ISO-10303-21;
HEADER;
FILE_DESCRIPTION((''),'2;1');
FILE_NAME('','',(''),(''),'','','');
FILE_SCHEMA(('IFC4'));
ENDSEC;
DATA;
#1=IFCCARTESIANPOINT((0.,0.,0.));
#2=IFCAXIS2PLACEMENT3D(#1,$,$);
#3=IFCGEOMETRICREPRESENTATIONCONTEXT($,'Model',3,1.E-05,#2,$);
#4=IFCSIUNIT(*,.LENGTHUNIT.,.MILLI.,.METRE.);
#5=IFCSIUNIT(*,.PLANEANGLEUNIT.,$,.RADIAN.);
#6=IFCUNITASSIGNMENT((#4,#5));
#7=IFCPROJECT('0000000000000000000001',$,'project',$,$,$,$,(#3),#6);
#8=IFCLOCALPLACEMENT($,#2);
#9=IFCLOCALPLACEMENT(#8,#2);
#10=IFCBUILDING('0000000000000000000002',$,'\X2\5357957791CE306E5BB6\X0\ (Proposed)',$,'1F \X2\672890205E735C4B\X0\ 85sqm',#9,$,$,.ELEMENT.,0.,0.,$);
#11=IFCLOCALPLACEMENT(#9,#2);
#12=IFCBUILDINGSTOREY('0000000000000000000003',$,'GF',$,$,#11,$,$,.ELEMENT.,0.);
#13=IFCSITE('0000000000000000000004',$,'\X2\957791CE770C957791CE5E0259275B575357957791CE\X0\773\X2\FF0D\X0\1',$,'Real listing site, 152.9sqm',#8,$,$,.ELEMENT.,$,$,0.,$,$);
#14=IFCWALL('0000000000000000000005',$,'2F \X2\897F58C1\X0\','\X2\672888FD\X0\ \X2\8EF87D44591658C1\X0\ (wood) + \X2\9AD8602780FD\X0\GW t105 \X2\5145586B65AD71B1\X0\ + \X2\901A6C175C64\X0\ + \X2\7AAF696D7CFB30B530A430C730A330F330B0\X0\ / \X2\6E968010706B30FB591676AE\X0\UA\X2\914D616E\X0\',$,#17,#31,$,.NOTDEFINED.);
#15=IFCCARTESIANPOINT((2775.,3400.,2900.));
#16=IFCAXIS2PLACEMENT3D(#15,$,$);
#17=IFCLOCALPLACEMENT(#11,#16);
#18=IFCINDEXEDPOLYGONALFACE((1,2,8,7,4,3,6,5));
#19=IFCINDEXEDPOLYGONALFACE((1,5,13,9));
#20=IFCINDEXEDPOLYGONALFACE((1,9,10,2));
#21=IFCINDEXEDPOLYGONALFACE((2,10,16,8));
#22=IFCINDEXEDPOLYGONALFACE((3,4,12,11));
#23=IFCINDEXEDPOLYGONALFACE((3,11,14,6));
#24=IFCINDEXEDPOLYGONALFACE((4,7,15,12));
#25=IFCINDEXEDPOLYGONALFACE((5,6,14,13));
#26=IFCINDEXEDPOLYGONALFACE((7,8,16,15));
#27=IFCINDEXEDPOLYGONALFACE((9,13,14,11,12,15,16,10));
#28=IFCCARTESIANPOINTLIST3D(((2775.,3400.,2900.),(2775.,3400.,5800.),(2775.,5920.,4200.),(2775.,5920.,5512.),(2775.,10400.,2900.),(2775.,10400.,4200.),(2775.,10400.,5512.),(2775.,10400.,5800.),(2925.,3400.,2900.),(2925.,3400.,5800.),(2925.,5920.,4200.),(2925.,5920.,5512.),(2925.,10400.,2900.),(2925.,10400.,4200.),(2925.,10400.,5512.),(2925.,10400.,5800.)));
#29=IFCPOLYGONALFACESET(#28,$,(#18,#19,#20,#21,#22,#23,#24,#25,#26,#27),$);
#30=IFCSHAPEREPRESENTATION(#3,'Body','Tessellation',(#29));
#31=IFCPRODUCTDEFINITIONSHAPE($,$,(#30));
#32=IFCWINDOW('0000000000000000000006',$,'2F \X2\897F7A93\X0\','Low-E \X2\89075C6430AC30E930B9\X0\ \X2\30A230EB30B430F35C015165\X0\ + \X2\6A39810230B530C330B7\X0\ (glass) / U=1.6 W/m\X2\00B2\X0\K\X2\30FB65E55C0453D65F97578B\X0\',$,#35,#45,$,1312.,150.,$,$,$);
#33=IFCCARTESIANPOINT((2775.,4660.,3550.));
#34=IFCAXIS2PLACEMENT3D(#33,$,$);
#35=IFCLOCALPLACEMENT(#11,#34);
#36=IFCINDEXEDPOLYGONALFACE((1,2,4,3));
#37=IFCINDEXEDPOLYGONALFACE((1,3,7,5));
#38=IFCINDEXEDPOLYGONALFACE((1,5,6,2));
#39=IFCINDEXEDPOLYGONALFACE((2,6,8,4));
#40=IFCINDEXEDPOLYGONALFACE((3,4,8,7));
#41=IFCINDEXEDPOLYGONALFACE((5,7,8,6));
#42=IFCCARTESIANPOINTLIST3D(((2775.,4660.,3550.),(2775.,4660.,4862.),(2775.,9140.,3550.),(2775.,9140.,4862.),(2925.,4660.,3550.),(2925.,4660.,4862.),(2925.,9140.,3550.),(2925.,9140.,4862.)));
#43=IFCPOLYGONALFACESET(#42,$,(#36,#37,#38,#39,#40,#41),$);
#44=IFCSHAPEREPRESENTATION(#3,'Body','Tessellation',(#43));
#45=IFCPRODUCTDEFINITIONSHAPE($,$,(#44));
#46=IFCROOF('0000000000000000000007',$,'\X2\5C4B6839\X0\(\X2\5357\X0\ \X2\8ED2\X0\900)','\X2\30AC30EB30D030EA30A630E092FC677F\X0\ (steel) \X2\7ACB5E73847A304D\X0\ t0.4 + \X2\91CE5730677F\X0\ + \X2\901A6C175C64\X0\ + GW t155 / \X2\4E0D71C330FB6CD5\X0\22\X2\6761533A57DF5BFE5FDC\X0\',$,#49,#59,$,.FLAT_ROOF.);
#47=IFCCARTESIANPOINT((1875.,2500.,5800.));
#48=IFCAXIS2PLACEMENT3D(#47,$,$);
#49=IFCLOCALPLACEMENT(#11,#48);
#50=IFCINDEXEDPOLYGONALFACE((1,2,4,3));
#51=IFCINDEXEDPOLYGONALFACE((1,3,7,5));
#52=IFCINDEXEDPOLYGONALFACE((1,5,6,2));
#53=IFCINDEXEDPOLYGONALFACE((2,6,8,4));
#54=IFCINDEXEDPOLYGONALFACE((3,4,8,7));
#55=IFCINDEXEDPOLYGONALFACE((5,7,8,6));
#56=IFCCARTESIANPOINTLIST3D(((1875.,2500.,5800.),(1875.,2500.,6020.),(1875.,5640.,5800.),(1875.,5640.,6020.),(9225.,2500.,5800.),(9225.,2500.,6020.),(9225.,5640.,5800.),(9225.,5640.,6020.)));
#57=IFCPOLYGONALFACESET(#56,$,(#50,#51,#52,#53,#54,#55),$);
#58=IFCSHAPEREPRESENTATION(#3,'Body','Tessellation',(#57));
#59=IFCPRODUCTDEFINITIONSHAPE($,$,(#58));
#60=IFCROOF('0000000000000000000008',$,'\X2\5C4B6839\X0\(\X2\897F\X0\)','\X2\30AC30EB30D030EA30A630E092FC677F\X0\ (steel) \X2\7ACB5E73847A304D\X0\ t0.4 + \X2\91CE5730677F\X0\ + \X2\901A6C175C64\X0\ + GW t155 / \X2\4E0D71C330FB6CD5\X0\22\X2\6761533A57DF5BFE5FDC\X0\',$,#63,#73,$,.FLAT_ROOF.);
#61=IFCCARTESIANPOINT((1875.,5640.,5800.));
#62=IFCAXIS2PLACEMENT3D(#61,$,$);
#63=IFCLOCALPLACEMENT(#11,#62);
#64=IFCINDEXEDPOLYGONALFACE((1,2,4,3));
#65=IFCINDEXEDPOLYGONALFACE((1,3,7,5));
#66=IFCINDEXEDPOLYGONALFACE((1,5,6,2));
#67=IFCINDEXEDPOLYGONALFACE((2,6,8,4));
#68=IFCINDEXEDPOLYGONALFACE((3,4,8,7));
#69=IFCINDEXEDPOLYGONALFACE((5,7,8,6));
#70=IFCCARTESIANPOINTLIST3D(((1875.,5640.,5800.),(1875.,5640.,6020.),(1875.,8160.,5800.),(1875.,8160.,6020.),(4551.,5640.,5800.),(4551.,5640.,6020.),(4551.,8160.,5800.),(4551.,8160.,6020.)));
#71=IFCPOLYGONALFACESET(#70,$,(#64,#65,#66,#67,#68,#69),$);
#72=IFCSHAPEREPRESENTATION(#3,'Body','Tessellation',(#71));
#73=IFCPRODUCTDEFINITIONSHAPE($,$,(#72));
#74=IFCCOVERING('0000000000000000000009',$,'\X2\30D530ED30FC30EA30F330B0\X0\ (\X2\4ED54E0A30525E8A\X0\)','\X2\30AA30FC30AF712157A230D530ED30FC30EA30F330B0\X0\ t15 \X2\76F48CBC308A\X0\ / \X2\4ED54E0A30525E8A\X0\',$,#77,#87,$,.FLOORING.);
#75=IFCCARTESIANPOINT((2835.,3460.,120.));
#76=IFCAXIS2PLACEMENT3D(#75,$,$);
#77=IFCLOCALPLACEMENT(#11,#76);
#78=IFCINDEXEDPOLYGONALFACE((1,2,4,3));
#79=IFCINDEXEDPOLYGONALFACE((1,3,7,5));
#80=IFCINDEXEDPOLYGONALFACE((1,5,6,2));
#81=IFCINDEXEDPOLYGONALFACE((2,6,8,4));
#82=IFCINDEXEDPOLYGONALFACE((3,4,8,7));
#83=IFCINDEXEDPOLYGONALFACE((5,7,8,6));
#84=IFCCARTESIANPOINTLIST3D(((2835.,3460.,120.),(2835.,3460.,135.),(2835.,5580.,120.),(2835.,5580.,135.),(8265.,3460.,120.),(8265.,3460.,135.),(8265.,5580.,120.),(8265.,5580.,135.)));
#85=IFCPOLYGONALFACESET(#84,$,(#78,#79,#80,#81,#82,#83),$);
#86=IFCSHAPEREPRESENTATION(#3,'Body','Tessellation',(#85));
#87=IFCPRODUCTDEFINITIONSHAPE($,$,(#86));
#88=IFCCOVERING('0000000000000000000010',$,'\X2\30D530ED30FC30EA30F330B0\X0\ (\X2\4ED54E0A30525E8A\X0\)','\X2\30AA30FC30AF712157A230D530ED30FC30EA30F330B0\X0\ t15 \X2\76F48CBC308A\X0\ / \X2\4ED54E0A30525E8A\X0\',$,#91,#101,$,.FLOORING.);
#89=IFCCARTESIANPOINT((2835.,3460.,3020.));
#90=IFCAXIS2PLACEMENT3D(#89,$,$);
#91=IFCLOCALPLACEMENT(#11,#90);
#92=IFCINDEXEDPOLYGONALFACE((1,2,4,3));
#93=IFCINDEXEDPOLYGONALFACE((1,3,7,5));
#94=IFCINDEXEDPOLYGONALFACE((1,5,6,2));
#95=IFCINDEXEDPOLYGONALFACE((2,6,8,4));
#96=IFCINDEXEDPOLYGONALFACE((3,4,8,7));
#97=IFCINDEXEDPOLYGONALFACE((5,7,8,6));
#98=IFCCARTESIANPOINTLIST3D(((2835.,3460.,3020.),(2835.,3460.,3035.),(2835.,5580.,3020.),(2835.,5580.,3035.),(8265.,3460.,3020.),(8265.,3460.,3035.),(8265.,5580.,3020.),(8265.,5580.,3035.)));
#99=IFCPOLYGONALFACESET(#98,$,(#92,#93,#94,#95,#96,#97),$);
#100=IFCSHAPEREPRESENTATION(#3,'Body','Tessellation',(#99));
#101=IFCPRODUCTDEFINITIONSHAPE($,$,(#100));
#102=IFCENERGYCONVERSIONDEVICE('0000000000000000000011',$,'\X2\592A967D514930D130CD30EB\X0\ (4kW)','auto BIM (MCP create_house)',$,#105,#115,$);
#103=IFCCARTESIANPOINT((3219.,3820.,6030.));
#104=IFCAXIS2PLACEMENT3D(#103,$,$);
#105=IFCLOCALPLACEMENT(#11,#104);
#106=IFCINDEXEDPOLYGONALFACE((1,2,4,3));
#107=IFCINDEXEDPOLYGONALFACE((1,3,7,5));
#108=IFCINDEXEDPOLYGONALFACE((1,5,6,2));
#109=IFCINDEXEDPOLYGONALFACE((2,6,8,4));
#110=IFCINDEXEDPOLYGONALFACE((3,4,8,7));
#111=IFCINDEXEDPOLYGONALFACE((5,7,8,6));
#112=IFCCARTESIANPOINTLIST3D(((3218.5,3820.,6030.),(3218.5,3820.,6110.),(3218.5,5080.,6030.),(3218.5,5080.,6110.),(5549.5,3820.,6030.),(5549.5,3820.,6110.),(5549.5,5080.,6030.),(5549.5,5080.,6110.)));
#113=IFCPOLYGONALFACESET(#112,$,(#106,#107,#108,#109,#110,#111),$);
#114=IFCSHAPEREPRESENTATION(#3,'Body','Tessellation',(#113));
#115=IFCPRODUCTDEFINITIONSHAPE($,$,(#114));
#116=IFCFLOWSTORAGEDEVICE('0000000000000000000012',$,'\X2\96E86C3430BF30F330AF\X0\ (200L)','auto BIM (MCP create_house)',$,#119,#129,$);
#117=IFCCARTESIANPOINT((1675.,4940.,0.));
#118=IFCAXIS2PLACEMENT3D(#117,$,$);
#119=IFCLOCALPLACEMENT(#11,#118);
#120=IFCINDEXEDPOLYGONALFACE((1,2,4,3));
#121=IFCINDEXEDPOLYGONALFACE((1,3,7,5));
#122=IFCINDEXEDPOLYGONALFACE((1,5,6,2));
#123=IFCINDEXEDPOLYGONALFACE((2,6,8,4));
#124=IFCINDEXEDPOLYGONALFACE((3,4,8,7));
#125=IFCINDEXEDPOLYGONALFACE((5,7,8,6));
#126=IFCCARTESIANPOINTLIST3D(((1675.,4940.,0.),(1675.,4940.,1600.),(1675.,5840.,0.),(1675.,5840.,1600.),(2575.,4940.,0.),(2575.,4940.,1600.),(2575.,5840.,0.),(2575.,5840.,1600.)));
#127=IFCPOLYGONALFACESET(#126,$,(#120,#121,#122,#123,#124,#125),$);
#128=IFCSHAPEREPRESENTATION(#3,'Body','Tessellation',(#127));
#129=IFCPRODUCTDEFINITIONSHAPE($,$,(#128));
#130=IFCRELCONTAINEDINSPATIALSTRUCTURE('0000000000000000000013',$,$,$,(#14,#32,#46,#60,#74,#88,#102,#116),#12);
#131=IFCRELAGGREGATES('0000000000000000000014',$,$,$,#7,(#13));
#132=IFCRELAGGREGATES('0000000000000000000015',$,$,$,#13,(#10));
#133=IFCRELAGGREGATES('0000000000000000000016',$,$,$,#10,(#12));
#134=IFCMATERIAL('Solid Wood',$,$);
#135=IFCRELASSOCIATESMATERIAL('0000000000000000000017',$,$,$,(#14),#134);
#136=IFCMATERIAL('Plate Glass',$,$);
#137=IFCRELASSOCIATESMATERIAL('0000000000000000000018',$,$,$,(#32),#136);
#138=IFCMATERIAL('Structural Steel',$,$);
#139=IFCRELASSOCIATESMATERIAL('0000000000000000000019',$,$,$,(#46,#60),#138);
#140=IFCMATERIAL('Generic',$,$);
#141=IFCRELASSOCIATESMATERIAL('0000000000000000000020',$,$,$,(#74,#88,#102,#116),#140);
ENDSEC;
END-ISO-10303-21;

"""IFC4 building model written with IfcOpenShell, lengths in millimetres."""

from ifc_helpers import new_model, si_unit, frame, frame_2d, origin, place, context, project, spatial, rectangle, extrude, material, element, fill, save


model = new_model("IFC4")

# Units and contexts
model_context = context("Model", 3, precision=1e-05, world=origin())
ifc_project = project(units=[si_unit("LENGTHUNIT", "METRE", prefix="MILLI"), si_unit("PLANEANGLEUNIT", "RADIAN")], contexts=[model_context])

# Site, building, storey
site_placement = place(None, origin())
site = spatial("IfcSite", under=ifc_project, at=site_placement, Name="長野県長野市大字南長野773－1", ObjectType="Real listing site, 152.9sqm", CompositionType="ELEMENT", RefElevation=0.0)
building_placement = place(site_placement, origin())
building = spatial("IfcBuilding", under=site, at=building_placement, Name="南長野の家 (Proposed)", ObjectType="1F 木造平屋 85sqm", CompositionType="ELEMENT", ElevationOfRefHeight=0.0, ElevationOfTerrain=0.0)
storey_placement = place(building_placement, origin())
storey = spatial("IfcBuildingStorey", under=building, at=storey_placement, Name="GF", CompositionType="ELEMENT", Elevation=0.0)

# Shared definitions
ifc_material_1 = material(Name="Solid Wood")
ifc_material_2 = material(Name="Generic")

# Shared definitions
ifc_material_3 = material(Name="Plate Glass")

# Wall, opening, window
wall_1_placement = place(storey_placement, frame((2775.0, 3400.0, 2900.0)))
wall_1 = element("IfcWall", 1, at=wall_1_placement, inside=storey, material=ifc_material_1, Name="2F 西壁", Description="木製 軸組外壁 (wood) + 高性能GW t105 充填断熱 + 通気層 + 窯業系サイディング / 準耐火・外皮UA配慮", PredefinedType="NOTDEFINED", context=model_context, shape_type="SweptSolid", body=[
    extrude(rectangle(XDim=150.0, YDim=7000.0, at=frame_2d((75.0, 3500.0))), frame((2775.0, 3400.0, 2900.0)), (0.0, 0.0, 1.0), 2900.0),
])
opening_1_placement = place(storey_placement, frame((2775.0, 4660.0, 3550.0)))
opening_1 = element("IfcOpeningElement", 2, at=opening_1_placement, cuts=wall_1, PredefinedType="NOTDEFINED", context=model_context, shape_type="SweptSolid", body=[
    extrude(rectangle(XDim=150.0, YDim=4480.0, at=frame_2d((75.0, 2240.0))), frame((2775.0, 4660.0, 3550.0)), (0.0, 0.0, 1.0), 1312.0),
])
window_1_placement = place(storey_placement, frame((2775.0, 4660.0, 3550.0)))
window_1 = element("IfcWindow", 3, at=window_1_placement, inside=storey, material=ifc_material_3, Name="2F 西窓", Description="Low-E 複層ガラス アルゴン封入 + 樹脂サッシ (glass) / U=1.6 W/m²K・日射取得型", OverallHeight=1312.0, OverallWidth=150.0, context=model_context, shape_type="SweptSolid", body=[
    extrude(rectangle(XDim=150.0, YDim=4480.0, at=frame_2d((75.0, 2240.0))), frame((2775.0, 4660.0, 3550.0)), (0.0, 0.0, 1.0), 1312.0),
])
fill(opening_1, window_1)

# Roofs
ifc_material_4 = material(Name="Structural Steel")
roof_1_placement = place(storey_placement, frame((1875.0, 2500.0, 5800.0)))
element("IfcRoof", 4, at=roof_1_placement, inside=storey, material=ifc_material_4, Name="屋根(南 軒900)", Description="ガルバリウム鋼板 (steel) 立平葺き t0.4 + 野地板 + 通気層 + GW t155 / 不燃・法22条区域対応", PredefinedType="FLAT_ROOF", context=model_context, shape_type="SweptSolid", body=[
    extrude(rectangle(XDim=7350.0, YDim=3140.0, at=frame_2d((3675.0, 1570.0))), frame((1875.0, 2500.0, 5800.0)), (0.0, 0.0, 1.0), 220.0),
])
roof_2_placement = place(storey_placement, frame((1875.0, 5640.0, 5800.0)))
element("IfcRoof", 5, at=roof_2_placement, inside=storey, material=ifc_material_4, Name="屋根(西)", Description="ガルバリウム鋼板 (steel) 立平葺き t0.4 + 野地板 + 通気層 + GW t155 / 不燃・法22条区域対応", PredefinedType="FLAT_ROOF", context=model_context, shape_type="SweptSolid", body=[
    extrude(rectangle(XDim=2676.0, YDim=2520.0, at=frame_2d((1338.0, 1260.0))), frame((1875.0, 5640.0, 5800.0)), (0.0, 0.0, 1.0), 220.0),
])

# Coverings
covering_1_placement = place(storey_placement, frame((2835.0, 3460.0, 120.0)))
element("IfcCovering", 6, at=covering_1_placement, inside=storey, material=ifc_material_2, Name="フローリング (仕上げ床)", Description="オーク無垢フローリング t15 直貼り / 仕上げ床", PredefinedType="FLOORING", context=model_context, shape_type="SweptSolid", body=[
    extrude(rectangle(XDim=5430.0, YDim=2120.0, at=frame_2d((2715.0, 1060.0))), frame((2835.0, 3460.0, 120.0)), (0.0, 0.0, 1.0), 15.0),
])
covering_2_placement = place(storey_placement, frame((2835.0, 3460.0, 3020.0)))
element("IfcCovering", 7, at=covering_2_placement, inside=storey, material=ifc_material_2, Name="フローリング (仕上げ床)", Description="オーク無垢フローリング t15 直貼り / 仕上げ床", PredefinedType="FLOORING", context=model_context, shape_type="SweptSolid", body=[
    extrude(rectangle(XDim=5430.0, YDim=2120.0, at=frame_2d((2715.0, 1060.0))), frame((2835.0, 3460.0, 3020.0)), (0.0, 0.0, 1.0), 15.0),
])

# Energy conversion device
energy_conversion_device_placement = place(storey_placement, frame((3219.0, 3820.0, 6030.0)))
element("IfcEnergyConversionDevice", 8, at=energy_conversion_device_placement, inside=storey, material=ifc_material_2, Name="太陽光パネル (4kW)", Description="auto BIM (MCP create_house)", context=model_context, shape_type="SweptSolid", body=[
    extrude(rectangle(XDim=2331.0, YDim=1260.0, at=frame_2d((1165.0, 630.0))), frame((3219.0, 3820.0, 6030.0)), (0.0, 0.0, 1.0), 80.0),
])

# Flow storage device
flow_storage_device_placement = place(storey_placement, frame((1675.0, 4940.0, 0.0)))
element("IfcFlowStorageDevice", 9, at=flow_storage_device_placement, inside=storey, material=ifc_material_2, Name="雨水タンク (200L)", Description="auto BIM (MCP create_house)", context=model_context, shape_type="SweptSolid", body=[
    extrude(rectangle(XDim=900.0, YDim=900.0, at=frame_2d((450.0, 450.0))), frame((1675.0, 4940.0, 0.0)), (0.0, 0.0, 1.0), 1600.0),
])

save(model, "model.ifc")
